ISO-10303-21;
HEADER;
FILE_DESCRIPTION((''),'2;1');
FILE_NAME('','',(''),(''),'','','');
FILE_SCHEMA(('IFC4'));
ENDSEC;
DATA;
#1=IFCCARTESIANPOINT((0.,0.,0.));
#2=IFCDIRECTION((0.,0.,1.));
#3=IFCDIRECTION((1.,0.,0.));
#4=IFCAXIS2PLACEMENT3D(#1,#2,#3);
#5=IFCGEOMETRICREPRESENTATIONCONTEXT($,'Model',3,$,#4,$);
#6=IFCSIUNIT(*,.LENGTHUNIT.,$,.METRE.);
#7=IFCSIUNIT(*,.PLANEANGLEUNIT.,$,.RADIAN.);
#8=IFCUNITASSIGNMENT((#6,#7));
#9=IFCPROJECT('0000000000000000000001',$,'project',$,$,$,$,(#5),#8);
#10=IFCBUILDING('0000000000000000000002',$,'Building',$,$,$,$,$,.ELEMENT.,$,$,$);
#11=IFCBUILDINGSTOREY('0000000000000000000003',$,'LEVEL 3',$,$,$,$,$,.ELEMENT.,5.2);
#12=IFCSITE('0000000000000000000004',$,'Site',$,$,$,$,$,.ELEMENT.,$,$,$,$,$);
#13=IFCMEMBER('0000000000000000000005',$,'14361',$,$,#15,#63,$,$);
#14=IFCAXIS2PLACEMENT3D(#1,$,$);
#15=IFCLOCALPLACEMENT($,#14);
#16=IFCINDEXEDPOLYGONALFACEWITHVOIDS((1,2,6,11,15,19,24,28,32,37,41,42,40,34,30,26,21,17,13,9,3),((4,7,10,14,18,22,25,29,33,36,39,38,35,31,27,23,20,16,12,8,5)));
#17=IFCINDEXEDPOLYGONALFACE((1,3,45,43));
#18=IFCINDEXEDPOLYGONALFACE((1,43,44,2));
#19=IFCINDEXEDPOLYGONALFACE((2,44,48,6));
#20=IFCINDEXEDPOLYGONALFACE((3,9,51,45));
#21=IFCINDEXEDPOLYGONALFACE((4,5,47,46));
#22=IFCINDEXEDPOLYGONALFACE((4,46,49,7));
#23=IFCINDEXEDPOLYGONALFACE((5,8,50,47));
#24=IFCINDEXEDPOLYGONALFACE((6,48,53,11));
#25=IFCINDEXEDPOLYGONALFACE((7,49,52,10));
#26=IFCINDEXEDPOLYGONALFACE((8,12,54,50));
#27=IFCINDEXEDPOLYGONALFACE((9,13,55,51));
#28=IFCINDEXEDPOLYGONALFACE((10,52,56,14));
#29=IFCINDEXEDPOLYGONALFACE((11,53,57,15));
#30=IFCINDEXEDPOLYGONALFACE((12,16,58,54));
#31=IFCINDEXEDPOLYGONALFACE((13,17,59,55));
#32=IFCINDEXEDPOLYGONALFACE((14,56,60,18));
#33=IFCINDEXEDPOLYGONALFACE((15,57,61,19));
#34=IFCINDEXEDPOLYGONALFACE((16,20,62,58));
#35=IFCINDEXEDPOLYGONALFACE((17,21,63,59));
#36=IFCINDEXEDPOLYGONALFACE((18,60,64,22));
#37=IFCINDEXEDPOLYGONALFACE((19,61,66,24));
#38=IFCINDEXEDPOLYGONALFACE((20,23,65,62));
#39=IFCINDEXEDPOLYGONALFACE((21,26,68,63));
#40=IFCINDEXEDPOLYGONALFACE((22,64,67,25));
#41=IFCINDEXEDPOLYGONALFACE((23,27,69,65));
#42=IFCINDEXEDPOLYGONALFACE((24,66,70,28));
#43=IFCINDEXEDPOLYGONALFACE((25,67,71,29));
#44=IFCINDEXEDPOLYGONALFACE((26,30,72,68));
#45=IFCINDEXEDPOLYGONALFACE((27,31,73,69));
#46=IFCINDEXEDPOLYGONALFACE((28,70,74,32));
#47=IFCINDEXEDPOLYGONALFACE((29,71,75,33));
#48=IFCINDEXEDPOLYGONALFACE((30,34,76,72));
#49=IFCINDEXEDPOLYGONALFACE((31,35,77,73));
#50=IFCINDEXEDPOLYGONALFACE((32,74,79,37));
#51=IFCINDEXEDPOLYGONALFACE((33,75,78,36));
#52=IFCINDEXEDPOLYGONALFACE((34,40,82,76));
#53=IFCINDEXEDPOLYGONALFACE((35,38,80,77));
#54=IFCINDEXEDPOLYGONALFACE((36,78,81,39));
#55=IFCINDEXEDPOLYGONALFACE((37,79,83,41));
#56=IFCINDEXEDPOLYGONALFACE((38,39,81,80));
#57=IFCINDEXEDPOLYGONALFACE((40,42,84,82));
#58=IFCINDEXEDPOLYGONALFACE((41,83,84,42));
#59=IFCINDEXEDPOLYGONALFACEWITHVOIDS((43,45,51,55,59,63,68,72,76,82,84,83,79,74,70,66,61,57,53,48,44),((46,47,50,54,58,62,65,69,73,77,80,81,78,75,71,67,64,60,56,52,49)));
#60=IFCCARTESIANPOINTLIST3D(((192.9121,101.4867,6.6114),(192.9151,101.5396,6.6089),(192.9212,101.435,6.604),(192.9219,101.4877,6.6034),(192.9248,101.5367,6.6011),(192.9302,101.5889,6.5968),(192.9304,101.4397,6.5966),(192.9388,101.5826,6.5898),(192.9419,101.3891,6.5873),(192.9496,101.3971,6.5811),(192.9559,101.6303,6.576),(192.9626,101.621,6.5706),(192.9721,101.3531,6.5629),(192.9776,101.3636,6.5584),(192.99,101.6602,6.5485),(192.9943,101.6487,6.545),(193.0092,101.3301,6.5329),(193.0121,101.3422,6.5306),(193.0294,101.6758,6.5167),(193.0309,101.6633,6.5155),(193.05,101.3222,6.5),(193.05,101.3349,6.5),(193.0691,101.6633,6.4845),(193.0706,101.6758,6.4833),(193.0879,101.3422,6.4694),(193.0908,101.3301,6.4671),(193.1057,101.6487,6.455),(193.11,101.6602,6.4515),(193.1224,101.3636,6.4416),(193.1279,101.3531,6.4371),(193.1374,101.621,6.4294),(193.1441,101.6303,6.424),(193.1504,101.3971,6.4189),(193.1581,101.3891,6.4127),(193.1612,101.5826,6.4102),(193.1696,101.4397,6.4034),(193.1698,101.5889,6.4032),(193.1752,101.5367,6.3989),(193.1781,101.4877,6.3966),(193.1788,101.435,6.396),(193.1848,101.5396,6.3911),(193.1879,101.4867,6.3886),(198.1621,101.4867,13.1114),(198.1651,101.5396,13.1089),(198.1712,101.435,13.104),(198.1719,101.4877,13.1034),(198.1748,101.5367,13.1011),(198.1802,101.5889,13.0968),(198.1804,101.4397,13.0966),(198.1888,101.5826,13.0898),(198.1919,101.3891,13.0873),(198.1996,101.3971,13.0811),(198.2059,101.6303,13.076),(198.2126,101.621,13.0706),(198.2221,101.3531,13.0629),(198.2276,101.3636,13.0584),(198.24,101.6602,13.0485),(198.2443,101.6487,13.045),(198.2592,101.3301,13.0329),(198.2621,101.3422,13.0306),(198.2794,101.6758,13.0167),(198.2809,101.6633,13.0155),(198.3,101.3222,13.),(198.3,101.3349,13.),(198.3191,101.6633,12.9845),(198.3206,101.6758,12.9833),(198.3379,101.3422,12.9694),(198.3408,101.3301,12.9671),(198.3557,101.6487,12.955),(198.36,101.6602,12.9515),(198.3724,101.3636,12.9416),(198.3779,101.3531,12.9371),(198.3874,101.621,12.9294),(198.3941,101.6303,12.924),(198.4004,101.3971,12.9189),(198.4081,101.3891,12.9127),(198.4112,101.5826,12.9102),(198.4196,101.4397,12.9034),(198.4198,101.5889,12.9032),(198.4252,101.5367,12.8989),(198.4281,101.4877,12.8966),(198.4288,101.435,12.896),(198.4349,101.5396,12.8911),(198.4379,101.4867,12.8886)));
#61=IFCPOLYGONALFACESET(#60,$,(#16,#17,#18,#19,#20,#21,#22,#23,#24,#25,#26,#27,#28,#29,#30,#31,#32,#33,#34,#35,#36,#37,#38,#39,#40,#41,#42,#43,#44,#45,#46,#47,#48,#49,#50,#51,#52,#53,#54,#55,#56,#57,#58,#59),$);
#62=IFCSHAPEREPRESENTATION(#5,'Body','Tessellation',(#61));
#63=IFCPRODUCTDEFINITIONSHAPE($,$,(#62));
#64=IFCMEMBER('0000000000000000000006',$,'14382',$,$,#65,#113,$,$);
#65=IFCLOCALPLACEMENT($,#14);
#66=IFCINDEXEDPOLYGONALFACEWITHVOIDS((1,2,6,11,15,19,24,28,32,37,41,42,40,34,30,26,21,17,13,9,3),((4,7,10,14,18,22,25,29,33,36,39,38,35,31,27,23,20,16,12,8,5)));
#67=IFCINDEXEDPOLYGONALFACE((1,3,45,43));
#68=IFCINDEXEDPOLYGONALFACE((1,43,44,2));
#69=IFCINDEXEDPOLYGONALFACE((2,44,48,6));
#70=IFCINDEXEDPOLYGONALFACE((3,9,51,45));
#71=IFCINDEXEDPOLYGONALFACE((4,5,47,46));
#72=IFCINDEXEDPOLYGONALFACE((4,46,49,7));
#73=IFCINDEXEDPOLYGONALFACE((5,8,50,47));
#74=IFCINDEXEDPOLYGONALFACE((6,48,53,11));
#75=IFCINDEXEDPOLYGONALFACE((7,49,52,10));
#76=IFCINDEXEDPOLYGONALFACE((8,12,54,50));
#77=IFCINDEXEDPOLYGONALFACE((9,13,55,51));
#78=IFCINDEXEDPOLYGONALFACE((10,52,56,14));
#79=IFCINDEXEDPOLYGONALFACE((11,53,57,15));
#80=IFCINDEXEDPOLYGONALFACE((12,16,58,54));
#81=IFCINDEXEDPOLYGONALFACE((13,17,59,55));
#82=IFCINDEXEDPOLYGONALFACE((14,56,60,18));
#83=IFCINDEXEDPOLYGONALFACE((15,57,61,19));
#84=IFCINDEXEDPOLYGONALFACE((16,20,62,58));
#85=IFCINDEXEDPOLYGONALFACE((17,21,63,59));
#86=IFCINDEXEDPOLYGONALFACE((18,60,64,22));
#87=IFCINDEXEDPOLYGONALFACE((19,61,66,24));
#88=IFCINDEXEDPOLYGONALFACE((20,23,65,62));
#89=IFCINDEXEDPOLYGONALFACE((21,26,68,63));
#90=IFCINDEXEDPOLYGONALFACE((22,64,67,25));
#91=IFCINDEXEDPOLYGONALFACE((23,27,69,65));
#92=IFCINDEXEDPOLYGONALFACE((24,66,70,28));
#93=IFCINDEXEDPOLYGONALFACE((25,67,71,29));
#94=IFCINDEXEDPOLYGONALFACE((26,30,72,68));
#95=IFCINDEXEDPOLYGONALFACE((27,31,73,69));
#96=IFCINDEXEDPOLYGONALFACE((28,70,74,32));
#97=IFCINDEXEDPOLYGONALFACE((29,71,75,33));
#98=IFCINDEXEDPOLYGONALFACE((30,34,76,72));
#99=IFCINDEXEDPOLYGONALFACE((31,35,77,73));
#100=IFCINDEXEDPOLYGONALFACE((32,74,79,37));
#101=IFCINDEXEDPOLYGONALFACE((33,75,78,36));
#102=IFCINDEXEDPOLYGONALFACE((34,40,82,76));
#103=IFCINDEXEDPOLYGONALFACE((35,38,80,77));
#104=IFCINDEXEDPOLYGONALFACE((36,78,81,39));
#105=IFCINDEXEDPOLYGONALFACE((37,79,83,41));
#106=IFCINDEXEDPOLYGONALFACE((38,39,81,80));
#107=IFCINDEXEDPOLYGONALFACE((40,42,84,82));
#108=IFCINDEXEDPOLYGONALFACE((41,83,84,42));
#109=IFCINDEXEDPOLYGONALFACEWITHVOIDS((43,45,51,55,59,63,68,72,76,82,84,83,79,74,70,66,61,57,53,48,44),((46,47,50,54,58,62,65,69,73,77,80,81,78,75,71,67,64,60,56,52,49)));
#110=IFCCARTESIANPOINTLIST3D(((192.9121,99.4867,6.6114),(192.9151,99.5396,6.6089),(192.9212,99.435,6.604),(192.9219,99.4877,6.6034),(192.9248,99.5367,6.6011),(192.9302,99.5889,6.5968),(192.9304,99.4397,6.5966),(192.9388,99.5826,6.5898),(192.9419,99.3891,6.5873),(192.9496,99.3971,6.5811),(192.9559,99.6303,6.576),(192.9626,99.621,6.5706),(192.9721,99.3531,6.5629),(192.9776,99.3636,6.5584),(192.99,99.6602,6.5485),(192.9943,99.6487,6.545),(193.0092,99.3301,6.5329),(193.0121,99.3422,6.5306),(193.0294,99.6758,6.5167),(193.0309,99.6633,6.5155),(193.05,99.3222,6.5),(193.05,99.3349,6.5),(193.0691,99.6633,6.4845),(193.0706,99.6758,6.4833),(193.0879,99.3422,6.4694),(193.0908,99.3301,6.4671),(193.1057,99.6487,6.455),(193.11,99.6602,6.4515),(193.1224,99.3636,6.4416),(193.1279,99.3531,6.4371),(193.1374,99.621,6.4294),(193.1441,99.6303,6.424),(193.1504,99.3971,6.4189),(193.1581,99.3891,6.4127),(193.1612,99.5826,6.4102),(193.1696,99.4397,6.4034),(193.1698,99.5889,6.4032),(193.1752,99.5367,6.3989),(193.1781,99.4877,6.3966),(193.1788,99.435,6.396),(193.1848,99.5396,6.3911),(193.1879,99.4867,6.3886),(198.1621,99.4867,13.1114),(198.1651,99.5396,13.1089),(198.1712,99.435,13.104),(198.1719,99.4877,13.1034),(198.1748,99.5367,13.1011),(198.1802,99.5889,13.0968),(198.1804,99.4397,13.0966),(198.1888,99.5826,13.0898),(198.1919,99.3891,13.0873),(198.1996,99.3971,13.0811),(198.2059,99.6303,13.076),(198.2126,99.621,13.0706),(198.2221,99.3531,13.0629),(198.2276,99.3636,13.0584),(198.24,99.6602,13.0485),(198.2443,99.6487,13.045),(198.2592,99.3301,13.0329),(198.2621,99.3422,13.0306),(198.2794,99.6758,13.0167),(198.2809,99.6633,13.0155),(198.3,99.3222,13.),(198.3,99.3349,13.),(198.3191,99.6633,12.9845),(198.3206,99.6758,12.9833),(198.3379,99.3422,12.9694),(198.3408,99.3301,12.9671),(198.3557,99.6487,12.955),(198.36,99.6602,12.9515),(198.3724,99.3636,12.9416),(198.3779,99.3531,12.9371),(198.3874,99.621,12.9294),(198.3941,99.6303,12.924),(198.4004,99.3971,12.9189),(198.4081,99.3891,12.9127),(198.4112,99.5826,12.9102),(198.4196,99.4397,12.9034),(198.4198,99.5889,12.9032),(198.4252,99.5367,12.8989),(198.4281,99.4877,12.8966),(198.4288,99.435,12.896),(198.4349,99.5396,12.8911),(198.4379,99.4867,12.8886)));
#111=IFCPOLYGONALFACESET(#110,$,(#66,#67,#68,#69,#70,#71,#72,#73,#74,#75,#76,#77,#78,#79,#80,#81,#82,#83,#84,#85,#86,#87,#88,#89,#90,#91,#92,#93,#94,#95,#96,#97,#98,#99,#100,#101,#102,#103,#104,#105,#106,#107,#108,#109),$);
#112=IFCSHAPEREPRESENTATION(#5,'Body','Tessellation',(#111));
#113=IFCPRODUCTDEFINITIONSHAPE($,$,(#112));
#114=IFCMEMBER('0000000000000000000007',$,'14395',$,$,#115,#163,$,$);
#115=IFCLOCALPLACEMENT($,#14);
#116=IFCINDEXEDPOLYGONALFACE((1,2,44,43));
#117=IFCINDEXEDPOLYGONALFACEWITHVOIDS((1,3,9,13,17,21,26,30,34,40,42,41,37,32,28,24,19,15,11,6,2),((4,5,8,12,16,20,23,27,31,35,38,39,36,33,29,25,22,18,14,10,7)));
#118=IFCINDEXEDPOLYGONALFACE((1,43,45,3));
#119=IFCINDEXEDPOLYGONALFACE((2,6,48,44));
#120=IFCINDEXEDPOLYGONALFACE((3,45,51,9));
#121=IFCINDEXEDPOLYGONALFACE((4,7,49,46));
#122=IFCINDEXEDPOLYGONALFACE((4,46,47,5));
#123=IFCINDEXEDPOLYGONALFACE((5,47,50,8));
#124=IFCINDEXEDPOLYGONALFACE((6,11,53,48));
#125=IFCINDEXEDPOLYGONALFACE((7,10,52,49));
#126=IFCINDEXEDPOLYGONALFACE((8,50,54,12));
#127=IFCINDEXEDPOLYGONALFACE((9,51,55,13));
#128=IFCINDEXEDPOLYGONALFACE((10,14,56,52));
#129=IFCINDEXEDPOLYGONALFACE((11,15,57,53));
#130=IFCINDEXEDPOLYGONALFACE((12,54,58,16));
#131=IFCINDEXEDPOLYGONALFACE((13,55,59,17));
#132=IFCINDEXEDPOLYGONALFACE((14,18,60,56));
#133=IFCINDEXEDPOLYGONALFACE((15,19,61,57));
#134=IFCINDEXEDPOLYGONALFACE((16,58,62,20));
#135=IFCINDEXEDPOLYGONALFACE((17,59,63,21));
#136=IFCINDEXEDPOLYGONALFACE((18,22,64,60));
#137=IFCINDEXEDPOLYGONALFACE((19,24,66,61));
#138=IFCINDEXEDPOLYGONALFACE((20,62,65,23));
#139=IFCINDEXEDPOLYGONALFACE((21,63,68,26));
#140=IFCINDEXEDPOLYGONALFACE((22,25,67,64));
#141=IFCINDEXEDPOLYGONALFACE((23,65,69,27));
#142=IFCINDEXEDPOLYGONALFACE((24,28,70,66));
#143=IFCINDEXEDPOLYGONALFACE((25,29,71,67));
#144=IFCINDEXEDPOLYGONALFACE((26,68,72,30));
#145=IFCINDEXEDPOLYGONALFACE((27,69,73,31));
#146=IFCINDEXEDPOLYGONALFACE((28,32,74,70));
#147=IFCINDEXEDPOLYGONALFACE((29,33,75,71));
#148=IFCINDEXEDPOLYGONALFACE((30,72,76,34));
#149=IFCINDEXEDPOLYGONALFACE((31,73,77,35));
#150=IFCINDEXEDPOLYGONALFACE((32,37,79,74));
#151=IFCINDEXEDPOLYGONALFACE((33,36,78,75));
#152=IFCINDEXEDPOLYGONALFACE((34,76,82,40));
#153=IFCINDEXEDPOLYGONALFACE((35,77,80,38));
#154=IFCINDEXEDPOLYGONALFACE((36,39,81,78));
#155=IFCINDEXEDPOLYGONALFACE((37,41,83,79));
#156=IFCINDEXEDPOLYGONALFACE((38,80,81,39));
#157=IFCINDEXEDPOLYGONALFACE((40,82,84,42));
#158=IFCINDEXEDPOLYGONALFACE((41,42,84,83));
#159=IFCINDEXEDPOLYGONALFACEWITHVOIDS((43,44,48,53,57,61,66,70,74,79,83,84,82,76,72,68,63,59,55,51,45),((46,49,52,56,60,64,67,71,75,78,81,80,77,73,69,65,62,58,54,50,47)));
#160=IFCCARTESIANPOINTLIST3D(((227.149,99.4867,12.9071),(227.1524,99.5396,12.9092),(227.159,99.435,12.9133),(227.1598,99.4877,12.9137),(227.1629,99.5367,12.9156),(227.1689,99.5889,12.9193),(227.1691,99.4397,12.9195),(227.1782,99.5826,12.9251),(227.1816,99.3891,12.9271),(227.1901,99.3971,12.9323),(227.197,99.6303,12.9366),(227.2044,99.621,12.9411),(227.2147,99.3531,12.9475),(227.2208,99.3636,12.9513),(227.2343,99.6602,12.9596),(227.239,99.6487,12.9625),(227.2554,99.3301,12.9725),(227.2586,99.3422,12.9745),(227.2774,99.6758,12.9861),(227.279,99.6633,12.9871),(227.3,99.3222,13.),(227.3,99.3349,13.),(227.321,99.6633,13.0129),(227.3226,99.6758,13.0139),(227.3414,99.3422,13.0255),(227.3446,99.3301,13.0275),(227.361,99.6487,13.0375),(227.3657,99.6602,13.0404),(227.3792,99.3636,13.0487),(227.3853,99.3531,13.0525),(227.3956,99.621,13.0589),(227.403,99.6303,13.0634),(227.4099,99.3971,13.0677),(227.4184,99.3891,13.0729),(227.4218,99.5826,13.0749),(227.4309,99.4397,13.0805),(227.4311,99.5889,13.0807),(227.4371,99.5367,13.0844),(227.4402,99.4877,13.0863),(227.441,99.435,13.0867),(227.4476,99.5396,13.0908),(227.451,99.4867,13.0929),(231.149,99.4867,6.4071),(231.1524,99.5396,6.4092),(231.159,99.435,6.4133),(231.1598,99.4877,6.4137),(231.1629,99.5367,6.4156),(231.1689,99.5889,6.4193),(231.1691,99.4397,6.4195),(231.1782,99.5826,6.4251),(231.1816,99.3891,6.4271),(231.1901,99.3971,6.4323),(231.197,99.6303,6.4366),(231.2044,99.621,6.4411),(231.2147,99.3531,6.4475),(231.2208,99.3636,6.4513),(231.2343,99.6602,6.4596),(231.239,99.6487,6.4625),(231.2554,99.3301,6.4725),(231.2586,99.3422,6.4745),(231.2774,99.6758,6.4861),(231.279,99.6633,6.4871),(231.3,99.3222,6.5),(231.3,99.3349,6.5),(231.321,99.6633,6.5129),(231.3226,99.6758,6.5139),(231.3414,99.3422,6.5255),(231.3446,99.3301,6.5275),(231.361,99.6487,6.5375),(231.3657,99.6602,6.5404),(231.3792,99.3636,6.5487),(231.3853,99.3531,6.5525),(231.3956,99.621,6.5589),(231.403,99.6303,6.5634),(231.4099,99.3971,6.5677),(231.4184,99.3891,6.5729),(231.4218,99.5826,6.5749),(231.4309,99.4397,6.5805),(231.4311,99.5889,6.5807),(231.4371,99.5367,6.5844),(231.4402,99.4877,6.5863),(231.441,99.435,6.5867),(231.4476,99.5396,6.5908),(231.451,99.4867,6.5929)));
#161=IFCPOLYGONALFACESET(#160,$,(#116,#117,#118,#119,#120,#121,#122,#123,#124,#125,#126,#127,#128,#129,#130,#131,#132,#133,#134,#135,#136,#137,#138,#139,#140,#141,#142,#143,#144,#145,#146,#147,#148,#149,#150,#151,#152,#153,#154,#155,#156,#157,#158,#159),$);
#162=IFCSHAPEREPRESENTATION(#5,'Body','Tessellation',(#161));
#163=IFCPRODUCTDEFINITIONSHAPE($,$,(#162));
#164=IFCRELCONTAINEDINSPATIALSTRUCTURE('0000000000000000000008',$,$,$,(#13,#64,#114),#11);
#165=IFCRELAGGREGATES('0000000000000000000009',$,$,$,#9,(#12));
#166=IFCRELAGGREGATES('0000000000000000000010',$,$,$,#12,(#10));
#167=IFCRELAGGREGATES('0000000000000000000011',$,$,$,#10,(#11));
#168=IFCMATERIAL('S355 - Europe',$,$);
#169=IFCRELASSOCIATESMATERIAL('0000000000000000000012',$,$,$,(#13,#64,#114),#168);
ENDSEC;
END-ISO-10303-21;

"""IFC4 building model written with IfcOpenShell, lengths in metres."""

from ifc_helpers import new_model, si_unit, frame, origin_with_axes, origin_2d_with_axis, place, context, project, spatial, hollow_circle, extrude, material, material_profile, profile_set, profile_usage, element, save


model = new_model("IFC4")

# Units and contexts
model_context = context("Model", 3, world=origin_with_axes())
ifc_project = project(units=[si_unit("LENGTHUNIT", "METRE"), si_unit("PLANEANGLEUNIT", "RADIAN")], contexts=[model_context])

# Site, building, storey
site = spatial("IfcSite", under=ifc_project, Name="Site", CompositionType="ELEMENT")
building = spatial("IfcBuilding", under=site, Name="Building", CompositionType="ELEMENT")
storey = spatial("IfcBuildingStorey", under=building, Name="LEVEL 3", CompositionType="ELEMENT", Elevation=5.2)

# Shared definitions
ifc_material = material(Name="S355 - Europe")

# Members
ifc_material_profile_1 = material_profile(ifc_material, hollow_circle(Radius=0.1778, WallThickness=0.0127, at=origin_2d_with_axis()))
ifc_profile_set_1 = profile_set([ifc_material_profile_1])
ifc_profile_usage_1 = profile_usage(ifc_profile_set_1, cardinal=10)
member_1_placement = place(None, frame((198.3, 101.5, 13.0), z_axis=(-0.628337, 0.0, -0.777941), x_axis=(0.0, -1.0, 0.0)))
element("IfcMember", 1, at=member_1_placement, inside=storey, material=ifc_profile_usage_1, Name="14361", context=model_context, shape_type="SweptSolid", body=[
    extrude(hollow_circle(Radius=0.1778, WallThickness=0.0127, at=origin_2d_with_axis()), origin_with_axes(), (0.0, 0.0, 1.0), 8.3554),
])
ifc_material_profile_2 = material_profile(ifc_material, hollow_circle(Radius=0.1778, WallThickness=0.0127, at=origin_2d_with_axis()))
ifc_profile_set_2 = profile_set([ifc_material_profile_2])
ifc_profile_usage_2 = profile_usage(ifc_profile_set_2, cardinal=10)
member_2_placement = place(None, frame((198.3, 99.5, 13.0), z_axis=(-0.628337, 0.0, -0.777941), x_axis=(0.0, -1.0, 0.0)))
element("IfcMember", 2, at=member_2_placement, inside=storey, material=ifc_profile_usage_2, Name="14382", context=model_context, shape_type="SweptSolid", body=[
    extrude(hollow_circle(Radius=0.1778, WallThickness=0.0127, at=origin_2d_with_axis()), origin_with_axes(), (0.0, 0.0, 1.0), 8.3554),
])
ifc_material_profile_3 = material_profile(ifc_material, hollow_circle(Radius=0.1778, WallThickness=0.0127, at=origin_2d_with_axis()))
ifc_profile_set_3 = profile_set([ifc_material_profile_3])
ifc_profile_usage_3 = profile_usage(ifc_profile_set_3, cardinal=10)
member_3_placement = place(None, frame((231.3, 99.5, 6.5), z_axis=(-0.524097, 0.0, 0.851658), x_axis=(0.0, -1.0, 0.0)))
element("IfcMember", 3, at=member_3_placement, inside=storey, material=ifc_profile_usage_3, Name="14395", context=model_context, shape_type="SweptSolid", body=[
    extrude(hollow_circle(Radius=0.1778, WallThickness=0.0127, at=origin_2d_with_axis()), origin_with_axes(), (0.0, 0.0, 1.0), 7.6322),
])

save(model, "model.ifc")
